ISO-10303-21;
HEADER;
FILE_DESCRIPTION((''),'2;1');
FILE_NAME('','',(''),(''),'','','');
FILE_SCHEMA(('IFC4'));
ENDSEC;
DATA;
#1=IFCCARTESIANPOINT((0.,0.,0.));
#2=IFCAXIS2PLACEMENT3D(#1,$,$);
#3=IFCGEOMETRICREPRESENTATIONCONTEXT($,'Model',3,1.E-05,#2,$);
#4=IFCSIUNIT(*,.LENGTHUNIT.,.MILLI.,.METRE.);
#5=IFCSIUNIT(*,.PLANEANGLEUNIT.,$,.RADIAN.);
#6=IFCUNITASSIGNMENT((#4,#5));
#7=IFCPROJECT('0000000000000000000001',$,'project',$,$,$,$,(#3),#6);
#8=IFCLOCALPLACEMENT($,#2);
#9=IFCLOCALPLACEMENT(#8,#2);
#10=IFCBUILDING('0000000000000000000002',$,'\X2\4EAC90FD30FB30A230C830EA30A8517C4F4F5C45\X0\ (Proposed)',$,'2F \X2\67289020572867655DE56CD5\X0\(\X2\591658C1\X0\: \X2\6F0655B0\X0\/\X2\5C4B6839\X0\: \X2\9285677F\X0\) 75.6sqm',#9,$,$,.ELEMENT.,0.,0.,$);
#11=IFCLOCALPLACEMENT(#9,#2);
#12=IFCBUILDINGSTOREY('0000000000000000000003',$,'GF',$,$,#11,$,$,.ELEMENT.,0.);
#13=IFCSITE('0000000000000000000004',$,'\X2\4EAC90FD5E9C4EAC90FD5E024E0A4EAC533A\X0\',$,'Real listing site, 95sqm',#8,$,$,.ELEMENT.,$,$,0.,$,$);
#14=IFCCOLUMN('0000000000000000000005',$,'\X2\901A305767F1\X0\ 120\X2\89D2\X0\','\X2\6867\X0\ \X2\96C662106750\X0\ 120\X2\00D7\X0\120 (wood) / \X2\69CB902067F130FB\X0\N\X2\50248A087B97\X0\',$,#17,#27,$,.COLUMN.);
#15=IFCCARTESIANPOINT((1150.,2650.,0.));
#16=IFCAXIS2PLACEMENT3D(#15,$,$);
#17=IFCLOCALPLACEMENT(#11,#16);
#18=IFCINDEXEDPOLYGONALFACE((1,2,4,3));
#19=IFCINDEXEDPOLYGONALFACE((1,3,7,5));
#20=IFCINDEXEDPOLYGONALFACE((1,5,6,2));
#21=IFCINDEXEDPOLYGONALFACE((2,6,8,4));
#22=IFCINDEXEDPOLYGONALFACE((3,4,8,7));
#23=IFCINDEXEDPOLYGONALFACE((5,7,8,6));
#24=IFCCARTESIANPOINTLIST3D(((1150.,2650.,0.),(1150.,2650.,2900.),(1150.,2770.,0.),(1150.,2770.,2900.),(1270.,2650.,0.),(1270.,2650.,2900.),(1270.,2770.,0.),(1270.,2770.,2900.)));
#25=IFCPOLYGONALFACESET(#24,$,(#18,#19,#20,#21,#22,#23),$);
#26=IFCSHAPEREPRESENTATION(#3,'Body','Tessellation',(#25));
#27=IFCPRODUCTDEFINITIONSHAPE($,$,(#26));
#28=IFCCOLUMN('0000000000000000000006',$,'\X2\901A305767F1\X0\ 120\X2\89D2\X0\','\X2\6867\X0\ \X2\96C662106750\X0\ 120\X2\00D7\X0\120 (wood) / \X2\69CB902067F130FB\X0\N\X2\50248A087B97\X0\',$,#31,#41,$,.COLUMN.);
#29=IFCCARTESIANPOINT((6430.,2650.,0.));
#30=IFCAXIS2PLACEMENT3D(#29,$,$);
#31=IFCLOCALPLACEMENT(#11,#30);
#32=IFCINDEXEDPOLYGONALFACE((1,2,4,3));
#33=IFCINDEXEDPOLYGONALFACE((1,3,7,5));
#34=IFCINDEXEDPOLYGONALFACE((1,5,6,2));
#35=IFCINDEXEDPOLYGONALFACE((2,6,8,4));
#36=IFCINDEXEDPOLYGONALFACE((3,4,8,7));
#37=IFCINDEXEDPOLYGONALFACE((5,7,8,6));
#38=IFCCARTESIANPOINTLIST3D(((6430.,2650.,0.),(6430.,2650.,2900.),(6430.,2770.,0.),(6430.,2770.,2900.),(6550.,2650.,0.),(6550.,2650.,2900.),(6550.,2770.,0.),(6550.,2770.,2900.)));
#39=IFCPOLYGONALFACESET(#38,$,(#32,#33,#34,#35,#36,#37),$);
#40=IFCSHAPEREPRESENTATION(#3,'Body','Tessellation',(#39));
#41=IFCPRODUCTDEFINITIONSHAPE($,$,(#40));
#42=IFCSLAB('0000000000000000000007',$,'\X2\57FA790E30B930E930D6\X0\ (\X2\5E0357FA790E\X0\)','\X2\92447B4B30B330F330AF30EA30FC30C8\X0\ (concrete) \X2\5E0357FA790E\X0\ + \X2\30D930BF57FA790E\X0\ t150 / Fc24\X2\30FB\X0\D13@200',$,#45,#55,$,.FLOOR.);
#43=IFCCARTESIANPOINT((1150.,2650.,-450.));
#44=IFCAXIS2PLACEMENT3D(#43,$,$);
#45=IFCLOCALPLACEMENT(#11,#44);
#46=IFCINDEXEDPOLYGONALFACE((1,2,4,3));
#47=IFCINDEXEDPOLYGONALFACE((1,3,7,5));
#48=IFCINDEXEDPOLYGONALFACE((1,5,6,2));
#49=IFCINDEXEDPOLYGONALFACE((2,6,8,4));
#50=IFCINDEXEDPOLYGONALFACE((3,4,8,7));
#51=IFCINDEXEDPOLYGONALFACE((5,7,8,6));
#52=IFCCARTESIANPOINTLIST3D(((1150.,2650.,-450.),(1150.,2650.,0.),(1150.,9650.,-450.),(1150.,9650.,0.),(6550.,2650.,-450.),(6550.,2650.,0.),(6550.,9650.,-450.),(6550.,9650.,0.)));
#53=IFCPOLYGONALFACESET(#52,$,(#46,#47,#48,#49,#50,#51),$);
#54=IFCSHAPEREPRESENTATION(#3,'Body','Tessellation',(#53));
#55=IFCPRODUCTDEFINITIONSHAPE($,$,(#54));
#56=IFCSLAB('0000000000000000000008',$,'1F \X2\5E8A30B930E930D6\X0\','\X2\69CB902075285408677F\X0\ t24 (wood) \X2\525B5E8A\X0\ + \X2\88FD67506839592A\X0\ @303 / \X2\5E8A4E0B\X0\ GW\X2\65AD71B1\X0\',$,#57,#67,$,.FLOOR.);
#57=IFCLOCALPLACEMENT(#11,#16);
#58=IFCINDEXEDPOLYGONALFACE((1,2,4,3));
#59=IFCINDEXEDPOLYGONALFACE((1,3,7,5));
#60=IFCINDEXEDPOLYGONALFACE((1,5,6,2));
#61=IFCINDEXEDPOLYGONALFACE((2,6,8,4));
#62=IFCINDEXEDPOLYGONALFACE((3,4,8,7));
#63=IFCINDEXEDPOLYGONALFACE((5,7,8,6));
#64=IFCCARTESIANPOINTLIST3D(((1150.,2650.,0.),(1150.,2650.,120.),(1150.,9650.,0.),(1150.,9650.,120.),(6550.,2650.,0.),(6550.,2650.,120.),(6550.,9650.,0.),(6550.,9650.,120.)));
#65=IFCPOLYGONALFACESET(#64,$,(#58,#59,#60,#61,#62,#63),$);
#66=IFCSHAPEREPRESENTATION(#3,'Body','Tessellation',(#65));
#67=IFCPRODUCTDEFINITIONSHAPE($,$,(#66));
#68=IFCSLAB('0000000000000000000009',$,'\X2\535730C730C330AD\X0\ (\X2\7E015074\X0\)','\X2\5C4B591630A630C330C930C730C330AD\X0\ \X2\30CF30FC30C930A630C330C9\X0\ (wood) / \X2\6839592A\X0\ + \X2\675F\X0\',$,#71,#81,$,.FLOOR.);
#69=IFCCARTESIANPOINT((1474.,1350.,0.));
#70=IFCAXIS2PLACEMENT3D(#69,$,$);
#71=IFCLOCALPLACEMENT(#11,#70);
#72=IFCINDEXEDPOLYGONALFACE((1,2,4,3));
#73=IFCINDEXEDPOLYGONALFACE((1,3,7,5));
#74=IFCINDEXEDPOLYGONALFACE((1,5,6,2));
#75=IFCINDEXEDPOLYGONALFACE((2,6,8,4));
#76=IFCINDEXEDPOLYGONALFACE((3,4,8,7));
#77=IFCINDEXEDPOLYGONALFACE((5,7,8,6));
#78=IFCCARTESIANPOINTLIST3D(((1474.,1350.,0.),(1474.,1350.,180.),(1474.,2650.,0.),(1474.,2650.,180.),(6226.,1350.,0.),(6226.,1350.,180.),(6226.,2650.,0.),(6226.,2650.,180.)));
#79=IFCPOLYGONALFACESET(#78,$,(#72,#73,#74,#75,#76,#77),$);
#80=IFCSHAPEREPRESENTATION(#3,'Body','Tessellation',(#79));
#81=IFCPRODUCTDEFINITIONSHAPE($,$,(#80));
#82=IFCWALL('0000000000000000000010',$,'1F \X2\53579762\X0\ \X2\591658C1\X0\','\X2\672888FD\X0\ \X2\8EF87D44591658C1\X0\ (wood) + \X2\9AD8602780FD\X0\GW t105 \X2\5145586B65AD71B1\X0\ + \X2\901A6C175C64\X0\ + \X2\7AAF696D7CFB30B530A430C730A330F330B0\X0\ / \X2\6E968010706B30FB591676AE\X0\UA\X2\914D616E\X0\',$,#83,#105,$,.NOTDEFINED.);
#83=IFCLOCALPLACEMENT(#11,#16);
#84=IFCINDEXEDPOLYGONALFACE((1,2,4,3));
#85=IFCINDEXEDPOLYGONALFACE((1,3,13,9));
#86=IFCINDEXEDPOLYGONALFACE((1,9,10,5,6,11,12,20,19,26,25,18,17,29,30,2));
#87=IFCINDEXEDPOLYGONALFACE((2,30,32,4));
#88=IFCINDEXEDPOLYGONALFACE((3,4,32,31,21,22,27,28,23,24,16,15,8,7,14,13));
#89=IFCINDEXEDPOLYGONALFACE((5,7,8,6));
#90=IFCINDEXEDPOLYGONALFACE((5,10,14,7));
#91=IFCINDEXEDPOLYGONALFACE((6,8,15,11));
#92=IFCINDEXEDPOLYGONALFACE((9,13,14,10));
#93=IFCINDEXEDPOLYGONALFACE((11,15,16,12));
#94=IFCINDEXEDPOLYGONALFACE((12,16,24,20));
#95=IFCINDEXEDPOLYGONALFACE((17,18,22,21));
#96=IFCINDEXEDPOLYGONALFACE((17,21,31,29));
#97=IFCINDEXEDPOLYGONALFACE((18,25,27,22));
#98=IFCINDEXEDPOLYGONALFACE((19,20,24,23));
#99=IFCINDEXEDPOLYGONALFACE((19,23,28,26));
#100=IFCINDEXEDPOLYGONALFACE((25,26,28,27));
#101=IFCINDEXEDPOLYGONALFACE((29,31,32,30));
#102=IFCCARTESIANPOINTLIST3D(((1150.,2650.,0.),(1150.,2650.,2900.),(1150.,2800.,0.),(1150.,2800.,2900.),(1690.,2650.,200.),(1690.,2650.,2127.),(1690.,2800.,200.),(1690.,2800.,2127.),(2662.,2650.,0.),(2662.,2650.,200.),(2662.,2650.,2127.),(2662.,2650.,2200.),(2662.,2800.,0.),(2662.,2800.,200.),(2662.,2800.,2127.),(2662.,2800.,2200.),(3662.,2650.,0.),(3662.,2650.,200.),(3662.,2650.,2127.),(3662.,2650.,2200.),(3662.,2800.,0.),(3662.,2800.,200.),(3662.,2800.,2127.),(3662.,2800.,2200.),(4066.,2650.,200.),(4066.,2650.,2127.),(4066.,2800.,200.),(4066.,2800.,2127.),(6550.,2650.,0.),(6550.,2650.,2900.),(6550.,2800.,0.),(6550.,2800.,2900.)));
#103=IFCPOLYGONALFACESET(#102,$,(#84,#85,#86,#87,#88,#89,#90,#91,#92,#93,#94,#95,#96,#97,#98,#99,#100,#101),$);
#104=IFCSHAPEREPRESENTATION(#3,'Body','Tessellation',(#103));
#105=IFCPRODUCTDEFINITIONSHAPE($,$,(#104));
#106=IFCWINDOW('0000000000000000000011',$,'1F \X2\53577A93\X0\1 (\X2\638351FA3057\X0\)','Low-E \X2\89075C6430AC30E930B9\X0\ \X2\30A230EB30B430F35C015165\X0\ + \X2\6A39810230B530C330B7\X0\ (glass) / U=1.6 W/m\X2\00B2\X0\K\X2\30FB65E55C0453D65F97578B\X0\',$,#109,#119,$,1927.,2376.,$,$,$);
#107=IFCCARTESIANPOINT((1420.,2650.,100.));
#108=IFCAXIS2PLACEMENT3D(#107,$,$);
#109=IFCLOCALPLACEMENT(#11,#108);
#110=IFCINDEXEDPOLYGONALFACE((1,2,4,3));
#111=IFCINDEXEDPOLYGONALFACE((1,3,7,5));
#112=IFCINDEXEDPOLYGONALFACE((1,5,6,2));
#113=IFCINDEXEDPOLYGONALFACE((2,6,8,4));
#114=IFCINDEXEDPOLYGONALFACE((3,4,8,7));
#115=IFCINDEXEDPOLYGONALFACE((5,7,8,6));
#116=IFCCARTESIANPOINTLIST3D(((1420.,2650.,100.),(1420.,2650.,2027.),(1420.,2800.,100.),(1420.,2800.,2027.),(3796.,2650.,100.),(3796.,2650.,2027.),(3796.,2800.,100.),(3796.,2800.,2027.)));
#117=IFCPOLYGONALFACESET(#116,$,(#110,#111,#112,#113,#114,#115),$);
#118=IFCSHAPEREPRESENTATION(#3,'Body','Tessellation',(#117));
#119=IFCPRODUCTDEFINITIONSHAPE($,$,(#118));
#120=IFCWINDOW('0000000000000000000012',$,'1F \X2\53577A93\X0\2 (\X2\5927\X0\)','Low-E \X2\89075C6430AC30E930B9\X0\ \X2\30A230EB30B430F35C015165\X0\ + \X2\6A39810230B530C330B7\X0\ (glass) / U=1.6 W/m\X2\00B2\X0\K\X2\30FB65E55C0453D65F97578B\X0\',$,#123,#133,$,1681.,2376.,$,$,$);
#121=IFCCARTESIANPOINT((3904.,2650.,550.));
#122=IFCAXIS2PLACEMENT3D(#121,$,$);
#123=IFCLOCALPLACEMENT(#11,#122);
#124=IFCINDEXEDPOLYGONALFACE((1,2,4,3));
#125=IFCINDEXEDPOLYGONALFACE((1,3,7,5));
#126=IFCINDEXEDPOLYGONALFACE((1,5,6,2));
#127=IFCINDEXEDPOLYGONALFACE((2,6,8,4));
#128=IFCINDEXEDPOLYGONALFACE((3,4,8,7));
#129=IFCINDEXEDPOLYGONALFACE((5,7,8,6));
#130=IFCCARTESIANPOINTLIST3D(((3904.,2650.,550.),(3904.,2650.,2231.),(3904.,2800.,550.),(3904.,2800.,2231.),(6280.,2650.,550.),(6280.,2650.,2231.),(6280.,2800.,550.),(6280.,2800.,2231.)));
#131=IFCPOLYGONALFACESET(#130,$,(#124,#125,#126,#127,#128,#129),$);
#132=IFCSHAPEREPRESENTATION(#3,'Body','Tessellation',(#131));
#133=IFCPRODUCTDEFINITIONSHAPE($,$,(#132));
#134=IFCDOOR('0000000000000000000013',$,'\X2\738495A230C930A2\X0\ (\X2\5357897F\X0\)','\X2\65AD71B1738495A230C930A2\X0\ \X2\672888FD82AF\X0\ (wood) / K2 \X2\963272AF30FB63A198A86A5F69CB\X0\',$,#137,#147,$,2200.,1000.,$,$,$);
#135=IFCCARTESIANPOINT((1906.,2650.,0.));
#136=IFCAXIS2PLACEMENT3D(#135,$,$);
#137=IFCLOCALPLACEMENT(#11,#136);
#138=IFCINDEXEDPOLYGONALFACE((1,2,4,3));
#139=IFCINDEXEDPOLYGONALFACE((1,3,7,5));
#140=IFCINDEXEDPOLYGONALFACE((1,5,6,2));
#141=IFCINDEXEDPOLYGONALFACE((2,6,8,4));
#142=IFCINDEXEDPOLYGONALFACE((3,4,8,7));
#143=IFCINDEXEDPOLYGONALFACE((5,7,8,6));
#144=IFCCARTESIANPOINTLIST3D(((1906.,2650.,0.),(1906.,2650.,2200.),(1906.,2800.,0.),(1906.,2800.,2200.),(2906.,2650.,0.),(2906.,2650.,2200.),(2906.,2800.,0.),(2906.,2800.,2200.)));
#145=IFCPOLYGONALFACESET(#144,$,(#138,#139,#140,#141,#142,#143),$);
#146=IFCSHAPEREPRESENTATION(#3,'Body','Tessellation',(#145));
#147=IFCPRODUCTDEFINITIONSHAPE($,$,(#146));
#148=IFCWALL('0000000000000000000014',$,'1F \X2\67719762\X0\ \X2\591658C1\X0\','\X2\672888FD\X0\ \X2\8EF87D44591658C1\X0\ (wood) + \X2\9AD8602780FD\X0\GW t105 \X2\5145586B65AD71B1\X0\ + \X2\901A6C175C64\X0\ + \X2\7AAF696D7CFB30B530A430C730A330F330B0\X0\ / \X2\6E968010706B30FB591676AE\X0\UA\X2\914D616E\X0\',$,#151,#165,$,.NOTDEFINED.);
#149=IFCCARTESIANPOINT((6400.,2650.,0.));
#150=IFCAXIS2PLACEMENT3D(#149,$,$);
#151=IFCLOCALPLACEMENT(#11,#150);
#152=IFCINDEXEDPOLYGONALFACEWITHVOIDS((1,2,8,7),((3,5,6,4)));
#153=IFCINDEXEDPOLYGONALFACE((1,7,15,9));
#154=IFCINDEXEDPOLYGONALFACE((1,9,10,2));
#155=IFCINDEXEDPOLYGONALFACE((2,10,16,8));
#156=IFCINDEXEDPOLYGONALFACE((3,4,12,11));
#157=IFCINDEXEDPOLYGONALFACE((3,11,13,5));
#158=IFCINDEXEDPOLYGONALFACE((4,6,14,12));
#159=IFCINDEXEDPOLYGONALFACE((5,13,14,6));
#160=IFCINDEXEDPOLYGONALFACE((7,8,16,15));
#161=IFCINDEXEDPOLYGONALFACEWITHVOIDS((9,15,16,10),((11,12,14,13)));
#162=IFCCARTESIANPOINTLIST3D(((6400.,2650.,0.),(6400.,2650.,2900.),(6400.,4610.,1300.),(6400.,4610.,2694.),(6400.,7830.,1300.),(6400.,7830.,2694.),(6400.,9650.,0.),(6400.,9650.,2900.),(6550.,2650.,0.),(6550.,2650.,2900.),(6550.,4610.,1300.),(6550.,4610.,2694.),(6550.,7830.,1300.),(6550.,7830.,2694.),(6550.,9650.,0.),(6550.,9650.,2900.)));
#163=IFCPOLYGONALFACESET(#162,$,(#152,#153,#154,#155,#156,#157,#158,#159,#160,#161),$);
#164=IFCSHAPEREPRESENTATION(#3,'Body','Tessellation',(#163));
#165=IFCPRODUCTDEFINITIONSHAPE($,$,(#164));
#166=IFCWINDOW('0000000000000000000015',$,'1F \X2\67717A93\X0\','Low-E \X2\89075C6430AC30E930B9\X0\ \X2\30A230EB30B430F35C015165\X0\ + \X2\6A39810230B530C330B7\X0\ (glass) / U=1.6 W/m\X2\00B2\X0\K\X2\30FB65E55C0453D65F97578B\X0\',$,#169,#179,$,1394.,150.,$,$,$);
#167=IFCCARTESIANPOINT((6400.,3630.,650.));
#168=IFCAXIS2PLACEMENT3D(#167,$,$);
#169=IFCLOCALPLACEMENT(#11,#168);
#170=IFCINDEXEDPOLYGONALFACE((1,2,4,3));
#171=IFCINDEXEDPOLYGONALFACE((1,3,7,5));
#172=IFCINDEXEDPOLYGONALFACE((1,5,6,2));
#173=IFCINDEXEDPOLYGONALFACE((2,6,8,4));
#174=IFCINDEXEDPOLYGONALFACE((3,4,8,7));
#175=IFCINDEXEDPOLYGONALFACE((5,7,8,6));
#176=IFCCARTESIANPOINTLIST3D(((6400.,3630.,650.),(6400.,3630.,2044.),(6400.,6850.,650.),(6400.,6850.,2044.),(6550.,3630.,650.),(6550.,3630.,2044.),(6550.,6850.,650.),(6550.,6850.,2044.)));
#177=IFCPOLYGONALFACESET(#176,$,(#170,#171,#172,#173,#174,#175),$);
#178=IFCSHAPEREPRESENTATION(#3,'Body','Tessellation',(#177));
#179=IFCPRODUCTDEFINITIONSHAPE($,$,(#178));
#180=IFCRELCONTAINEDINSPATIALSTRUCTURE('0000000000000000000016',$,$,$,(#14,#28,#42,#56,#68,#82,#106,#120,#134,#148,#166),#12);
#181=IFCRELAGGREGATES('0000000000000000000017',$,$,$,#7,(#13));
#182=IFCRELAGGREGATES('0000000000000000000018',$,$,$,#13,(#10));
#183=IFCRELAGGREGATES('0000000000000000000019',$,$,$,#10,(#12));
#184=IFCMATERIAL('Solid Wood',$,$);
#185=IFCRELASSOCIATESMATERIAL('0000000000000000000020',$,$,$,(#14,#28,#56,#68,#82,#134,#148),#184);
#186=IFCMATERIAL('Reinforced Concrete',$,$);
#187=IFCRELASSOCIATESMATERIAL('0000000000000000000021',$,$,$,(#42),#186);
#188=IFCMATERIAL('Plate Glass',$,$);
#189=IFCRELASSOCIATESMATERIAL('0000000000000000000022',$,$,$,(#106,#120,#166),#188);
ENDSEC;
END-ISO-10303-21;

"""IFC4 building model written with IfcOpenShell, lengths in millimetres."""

from ifc_helpers import new_model, si_unit, frame, frame_2d, origin, place, context, project, spatial, rectangle, extrude, material, element, fill, save


model = new_model("IFC4")

# Units and contexts
model_context = context("Model", 3, precision=1e-05, world=origin())
ifc_project = project(units=[si_unit("LENGTHUNIT", "METRE", prefix="MILLI"), si_unit("PLANEANGLEUNIT", "RADIAN")], contexts=[model_context])

# Site, building, storey
site_placement = place(None, origin())
site = spatial("IfcSite", under=ifc_project, at=site_placement, Name="京都府京都市上京区", ObjectType="Real listing site, 95sqm", CompositionType="ELEMENT", RefElevation=0.0)
building_placement = place(site_placement, origin())
building = spatial("IfcBuilding", under=site, at=building_placement, Name="京都・アトリエ兼住居 (Proposed)", ObjectType="2F 木造在来工法(外壁: 漆喰/屋根: 銅板) 75.6sqm", CompositionType="ELEMENT", ElevationOfRefHeight=0.0, ElevationOfTerrain=0.0)
storey_placement = place(building_placement, origin())
storey = spatial("IfcBuildingStorey", under=building, at=storey_placement, Name="GF", CompositionType="ELEMENT", Elevation=0.0)

# Columns
ifc_material_1 = material(Name="Solid Wood")
column_1_placement = place(storey_placement, frame((1150.0, 2650.0, 0.0)))
element("IfcColumn", 1, at=column_1_placement, inside=storey, material=ifc_material_1, Name="通し柱 120角", Description="桧 集成材 120×120 (wood) / 構造柱・N値計算", PredefinedType="COLUMN", context=model_context, shape_type="SweptSolid", body=[
    extrude(rectangle(XDim=120.0, YDim=120.0, at=frame_2d((60.0, 60.0))), frame((1150.0, 2650.0, 0.0)), (0.0, 0.0, 1.0), 2900.0),
])
column_2_placement = place(storey_placement, frame((6430.0, 2650.0, 0.0)))
element("IfcColumn", 2, at=column_2_placement, inside=storey, material=ifc_material_1, Name="通し柱 120角", Description="桧 集成材 120×120 (wood) / 構造柱・N値計算", PredefinedType="COLUMN", context=model_context, shape_type="SweptSolid", body=[
    extrude(rectangle(XDim=120.0, YDim=120.0, at=frame_2d((60.0, 60.0))), frame((6430.0, 2650.0, 0.0)), (0.0, 0.0, 1.0), 2900.0),
])

# Slabs
ifc_material_2 = material(Name="Reinforced Concrete")
slab_1_placement = place(storey_placement, frame((1150.0, 2650.0, -450.0)))
element("IfcSlab", 3, at=slab_1_placement, inside=storey, material=ifc_material_2, Name="基礎スラブ (布基礎)", Description="鉄筋コンクリート (concrete) 布基礎 + ベタ基礎 t150 / Fc24・D13@200", PredefinedType="FLOOR", context=model_context, shape_type="SweptSolid", body=[
    extrude(rectangle(XDim=5400.0, YDim=7000.0, at=frame_2d((2700.0, 3500.0))), frame((1150.0, 2650.0, -450.0)), (0.0, 0.0, 1.0), 450.0),
])
slab_2_placement = place(storey_placement, frame((1150.0, 2650.0, 0.0)))
element("IfcSlab", 4, at=slab_2_placement, inside=storey, material=ifc_material_1, Name="1F 床スラブ", Description="構造用合板 t24 (wood) 剛床 + 製材根太 @303 / 床下 GW断熱", PredefinedType="FLOOR", context=model_context, shape_type="SweptSolid", body=[
    extrude(rectangle(XDim=5400.0, YDim=7000.0, at=frame_2d((2700.0, 3500.0))), frame((1150.0, 2650.0, 0.0)), (0.0, 0.0, 1.0), 120.0),
])
slab_3_placement = place(storey_placement, frame((1474.0, 1350.0, 0.0)))
element("IfcSlab", 5, at=slab_3_placement, inside=storey, material=ifc_material_1, Name="南デッキ (縁側)", Description="屋外ウッドデッキ ハードウッド (wood) / 根太 + 束", PredefinedType="FLOOR", context=model_context, shape_type="SweptSolid", body=[
    extrude(rectangle(XDim=4752.0, YDim=1300.0, at=frame_2d((2376.0, 650.0))), frame((1474.0, 1350.0, 0.0)), (0.0, 0.0, 1.0), 180.0),
])

# Wall, openings, windows, door
wall_1_placement = place(storey_placement, frame((1150.0, 2650.0, 0.0)))
wall_1 = element("IfcWall", 6, at=wall_1_placement, inside=storey, material=ifc_material_1, Name="1F 南面 外壁", Description="木製 軸組外壁 (wood) + 高性能GW t105 充填断熱 + 通気層 + 窯業系サイディング / 準耐火・外皮UA配慮", PredefinedType="NOTDEFINED", context=model_context, shape_type="SweptSolid", body=[
    extrude(rectangle(XDim=5400.0, YDim=150.0, at=frame_2d((2700.0, 75.0))), frame((1150.0, 2650.0, 0.0)), (0.0, 0.0, 1.0), 2900.0),
])
opening_1_placement = place(storey_placement, frame((1420.0, 2650.0, 100.0)))
opening_1 = element("IfcOpeningElement", 7, at=opening_1_placement, cuts=wall_1, PredefinedType="NOTDEFINED", context=model_context, shape_type="SweptSolid", body=[
    extrude(rectangle(XDim=2376.0, YDim=150.0, at=frame_2d((1188.0, 75.0))), frame((1420.0, 2650.0, 100.0)), (0.0, 0.0, 1.0), 1927.0),
])
opening_2_placement = place(storey_placement, frame((3904.0, 2650.0, 550.0)))
opening_2 = element("IfcOpeningElement", 8, at=opening_2_placement, cuts=wall_1, PredefinedType="NOTDEFINED", context=model_context, shape_type="SweptSolid", body=[
    extrude(rectangle(XDim=2376.0, YDim=150.0, at=frame_2d((1188.0, 75.0))), frame((3904.0, 2650.0, 550.0)), (0.0, 0.0, 1.0), 1681.0),
])
opening_3_placement = place(storey_placement, frame((1906.0, 2650.0, 0.0)))
opening_3 = element("IfcOpeningElement", 9, at=opening_3_placement, cuts=wall_1, PredefinedType="NOTDEFINED", context=model_context, shape_type="SweptSolid", body=[
    extrude(rectangle(XDim=1000.0, YDim=150.0, at=frame_2d((500.0, 75.0))), frame((1906.0, 2650.0, 0.0)), (0.0, 0.0, 1.0), 2200.0),
])
ifc_material_3 = material(Name="Plate Glass")
window_1_placement = place(storey_placement, frame((1420.0, 2650.0, 100.0)))
window_1 = element("IfcWindow", 10, at=window_1_placement, inside=storey, material=ifc_material_3, Name="1F 南窓1 (掃出し)", Description="Low-E 複層ガラス アルゴン封入 + 樹脂サッシ (glass) / U=1.6 W/m²K・日射取得型", OverallHeight=1927.0, OverallWidth=2376.0, context=model_context, shape_type="SweptSolid", body=[
    extrude(rectangle(XDim=2376.0, YDim=150.0, at=frame_2d((1188.0, 75.0))), frame((1420.0, 2650.0, 100.0)), (0.0, 0.0, 1.0), 1927.0),
])
fill(opening_1, window_1)
window_2_placement = place(storey_placement, frame((3904.0, 2650.0, 550.0)))
window_2 = element("IfcWindow", 11, at=window_2_placement, inside=storey, material=ifc_material_3, Name="1F 南窓2 (大)", Description="Low-E 複層ガラス アルゴン封入 + 樹脂サッシ (glass) / U=1.6 W/m²K・日射取得型", OverallHeight=1681.0, OverallWidth=2376.0, context=model_context, shape_type="SweptSolid", body=[
    extrude(rectangle(XDim=2376.0, YDim=150.0, at=frame_2d((1188.0, 75.0))), frame((3904.0, 2650.0, 550.0)), (0.0, 0.0, 1.0), 1681.0),
])
fill(opening_2, window_2)
door_placement = place(storey_placement, frame((1906.0, 2650.0, 0.0)))
door = element("IfcDoor", 12, at=door_placement, inside=storey, material=ifc_material_1, Name="玄関ドア (南西)", Description="断熱玄関ドア 木製芯 (wood) / K2 防犯・採風機構", OverallHeight=2200.0, OverallWidth=1000.0, context=model_context, shape_type="SweptSolid", body=[
    extrude(rectangle(XDim=1000.0, YDim=150.0, at=frame_2d((500.0, 75.0))), frame((1906.0, 2650.0, 0.0)), (0.0, 0.0, 1.0), 2200.0),
])
fill(opening_3, door)

# Wall, opening, window
wall_2_placement = place(storey_placement, frame((6400.0, 2650.0, 0.0)))
wall_2 = element("IfcWall", 13, at=wall_2_placement, inside=storey, material=ifc_material_1, Name="1F 東面 外壁", Description="木製 軸組外壁 (wood) + 高性能GW t105 充填断熱 + 通気層 + 窯業系サイディング / 準耐火・外皮UA配慮", PredefinedType="NOTDEFINED", context=model_context, shape_type="SweptSolid", body=[
    extrude(rectangle(XDim=150.0, YDim=7000.0, at=frame_2d((75.0, 3500.0))), frame((6400.0, 2650.0, 0.0)), (0.0, 0.0, 1.0), 2900.0),
])
opening_4_placement = place(storey_placement, frame((6400.0, 3630.0, 650.0)))
opening_4 = element("IfcOpeningElement", 14, at=opening_4_placement, cuts=wall_2, PredefinedType="NOTDEFINED", context=model_context, shape_type="SweptSolid", body=[
    extrude(rectangle(XDim=150.0, YDim=3220.0, at=frame_2d((75.0, 1610.0))), frame((6400.0, 3630.0, 650.0)), (0.0, 0.0, 1.0), 1394.0),
])
window_3_placement = place(storey_placement, frame((6400.0, 3630.0, 650.0)))
window_3 = element("IfcWindow", 15, at=window_3_placement, inside=storey, material=ifc_material_3, Name="1F 東窓", Description="Low-E 複層ガラス アルゴン封入 + 樹脂サッシ (glass) / U=1.6 W/m²K・日射取得型", OverallHeight=1394.0, OverallWidth=150.0, context=model_context, shape_type="SweptSolid", body=[
    extrude(rectangle(XDim=150.0, YDim=3220.0, at=frame_2d((75.0, 1610.0))), frame((6400.0, 3630.0, 650.0)), (0.0, 0.0, 1.0), 1394.0),
])
fill(opening_4, window_3)

save(model, "model.ifc")
